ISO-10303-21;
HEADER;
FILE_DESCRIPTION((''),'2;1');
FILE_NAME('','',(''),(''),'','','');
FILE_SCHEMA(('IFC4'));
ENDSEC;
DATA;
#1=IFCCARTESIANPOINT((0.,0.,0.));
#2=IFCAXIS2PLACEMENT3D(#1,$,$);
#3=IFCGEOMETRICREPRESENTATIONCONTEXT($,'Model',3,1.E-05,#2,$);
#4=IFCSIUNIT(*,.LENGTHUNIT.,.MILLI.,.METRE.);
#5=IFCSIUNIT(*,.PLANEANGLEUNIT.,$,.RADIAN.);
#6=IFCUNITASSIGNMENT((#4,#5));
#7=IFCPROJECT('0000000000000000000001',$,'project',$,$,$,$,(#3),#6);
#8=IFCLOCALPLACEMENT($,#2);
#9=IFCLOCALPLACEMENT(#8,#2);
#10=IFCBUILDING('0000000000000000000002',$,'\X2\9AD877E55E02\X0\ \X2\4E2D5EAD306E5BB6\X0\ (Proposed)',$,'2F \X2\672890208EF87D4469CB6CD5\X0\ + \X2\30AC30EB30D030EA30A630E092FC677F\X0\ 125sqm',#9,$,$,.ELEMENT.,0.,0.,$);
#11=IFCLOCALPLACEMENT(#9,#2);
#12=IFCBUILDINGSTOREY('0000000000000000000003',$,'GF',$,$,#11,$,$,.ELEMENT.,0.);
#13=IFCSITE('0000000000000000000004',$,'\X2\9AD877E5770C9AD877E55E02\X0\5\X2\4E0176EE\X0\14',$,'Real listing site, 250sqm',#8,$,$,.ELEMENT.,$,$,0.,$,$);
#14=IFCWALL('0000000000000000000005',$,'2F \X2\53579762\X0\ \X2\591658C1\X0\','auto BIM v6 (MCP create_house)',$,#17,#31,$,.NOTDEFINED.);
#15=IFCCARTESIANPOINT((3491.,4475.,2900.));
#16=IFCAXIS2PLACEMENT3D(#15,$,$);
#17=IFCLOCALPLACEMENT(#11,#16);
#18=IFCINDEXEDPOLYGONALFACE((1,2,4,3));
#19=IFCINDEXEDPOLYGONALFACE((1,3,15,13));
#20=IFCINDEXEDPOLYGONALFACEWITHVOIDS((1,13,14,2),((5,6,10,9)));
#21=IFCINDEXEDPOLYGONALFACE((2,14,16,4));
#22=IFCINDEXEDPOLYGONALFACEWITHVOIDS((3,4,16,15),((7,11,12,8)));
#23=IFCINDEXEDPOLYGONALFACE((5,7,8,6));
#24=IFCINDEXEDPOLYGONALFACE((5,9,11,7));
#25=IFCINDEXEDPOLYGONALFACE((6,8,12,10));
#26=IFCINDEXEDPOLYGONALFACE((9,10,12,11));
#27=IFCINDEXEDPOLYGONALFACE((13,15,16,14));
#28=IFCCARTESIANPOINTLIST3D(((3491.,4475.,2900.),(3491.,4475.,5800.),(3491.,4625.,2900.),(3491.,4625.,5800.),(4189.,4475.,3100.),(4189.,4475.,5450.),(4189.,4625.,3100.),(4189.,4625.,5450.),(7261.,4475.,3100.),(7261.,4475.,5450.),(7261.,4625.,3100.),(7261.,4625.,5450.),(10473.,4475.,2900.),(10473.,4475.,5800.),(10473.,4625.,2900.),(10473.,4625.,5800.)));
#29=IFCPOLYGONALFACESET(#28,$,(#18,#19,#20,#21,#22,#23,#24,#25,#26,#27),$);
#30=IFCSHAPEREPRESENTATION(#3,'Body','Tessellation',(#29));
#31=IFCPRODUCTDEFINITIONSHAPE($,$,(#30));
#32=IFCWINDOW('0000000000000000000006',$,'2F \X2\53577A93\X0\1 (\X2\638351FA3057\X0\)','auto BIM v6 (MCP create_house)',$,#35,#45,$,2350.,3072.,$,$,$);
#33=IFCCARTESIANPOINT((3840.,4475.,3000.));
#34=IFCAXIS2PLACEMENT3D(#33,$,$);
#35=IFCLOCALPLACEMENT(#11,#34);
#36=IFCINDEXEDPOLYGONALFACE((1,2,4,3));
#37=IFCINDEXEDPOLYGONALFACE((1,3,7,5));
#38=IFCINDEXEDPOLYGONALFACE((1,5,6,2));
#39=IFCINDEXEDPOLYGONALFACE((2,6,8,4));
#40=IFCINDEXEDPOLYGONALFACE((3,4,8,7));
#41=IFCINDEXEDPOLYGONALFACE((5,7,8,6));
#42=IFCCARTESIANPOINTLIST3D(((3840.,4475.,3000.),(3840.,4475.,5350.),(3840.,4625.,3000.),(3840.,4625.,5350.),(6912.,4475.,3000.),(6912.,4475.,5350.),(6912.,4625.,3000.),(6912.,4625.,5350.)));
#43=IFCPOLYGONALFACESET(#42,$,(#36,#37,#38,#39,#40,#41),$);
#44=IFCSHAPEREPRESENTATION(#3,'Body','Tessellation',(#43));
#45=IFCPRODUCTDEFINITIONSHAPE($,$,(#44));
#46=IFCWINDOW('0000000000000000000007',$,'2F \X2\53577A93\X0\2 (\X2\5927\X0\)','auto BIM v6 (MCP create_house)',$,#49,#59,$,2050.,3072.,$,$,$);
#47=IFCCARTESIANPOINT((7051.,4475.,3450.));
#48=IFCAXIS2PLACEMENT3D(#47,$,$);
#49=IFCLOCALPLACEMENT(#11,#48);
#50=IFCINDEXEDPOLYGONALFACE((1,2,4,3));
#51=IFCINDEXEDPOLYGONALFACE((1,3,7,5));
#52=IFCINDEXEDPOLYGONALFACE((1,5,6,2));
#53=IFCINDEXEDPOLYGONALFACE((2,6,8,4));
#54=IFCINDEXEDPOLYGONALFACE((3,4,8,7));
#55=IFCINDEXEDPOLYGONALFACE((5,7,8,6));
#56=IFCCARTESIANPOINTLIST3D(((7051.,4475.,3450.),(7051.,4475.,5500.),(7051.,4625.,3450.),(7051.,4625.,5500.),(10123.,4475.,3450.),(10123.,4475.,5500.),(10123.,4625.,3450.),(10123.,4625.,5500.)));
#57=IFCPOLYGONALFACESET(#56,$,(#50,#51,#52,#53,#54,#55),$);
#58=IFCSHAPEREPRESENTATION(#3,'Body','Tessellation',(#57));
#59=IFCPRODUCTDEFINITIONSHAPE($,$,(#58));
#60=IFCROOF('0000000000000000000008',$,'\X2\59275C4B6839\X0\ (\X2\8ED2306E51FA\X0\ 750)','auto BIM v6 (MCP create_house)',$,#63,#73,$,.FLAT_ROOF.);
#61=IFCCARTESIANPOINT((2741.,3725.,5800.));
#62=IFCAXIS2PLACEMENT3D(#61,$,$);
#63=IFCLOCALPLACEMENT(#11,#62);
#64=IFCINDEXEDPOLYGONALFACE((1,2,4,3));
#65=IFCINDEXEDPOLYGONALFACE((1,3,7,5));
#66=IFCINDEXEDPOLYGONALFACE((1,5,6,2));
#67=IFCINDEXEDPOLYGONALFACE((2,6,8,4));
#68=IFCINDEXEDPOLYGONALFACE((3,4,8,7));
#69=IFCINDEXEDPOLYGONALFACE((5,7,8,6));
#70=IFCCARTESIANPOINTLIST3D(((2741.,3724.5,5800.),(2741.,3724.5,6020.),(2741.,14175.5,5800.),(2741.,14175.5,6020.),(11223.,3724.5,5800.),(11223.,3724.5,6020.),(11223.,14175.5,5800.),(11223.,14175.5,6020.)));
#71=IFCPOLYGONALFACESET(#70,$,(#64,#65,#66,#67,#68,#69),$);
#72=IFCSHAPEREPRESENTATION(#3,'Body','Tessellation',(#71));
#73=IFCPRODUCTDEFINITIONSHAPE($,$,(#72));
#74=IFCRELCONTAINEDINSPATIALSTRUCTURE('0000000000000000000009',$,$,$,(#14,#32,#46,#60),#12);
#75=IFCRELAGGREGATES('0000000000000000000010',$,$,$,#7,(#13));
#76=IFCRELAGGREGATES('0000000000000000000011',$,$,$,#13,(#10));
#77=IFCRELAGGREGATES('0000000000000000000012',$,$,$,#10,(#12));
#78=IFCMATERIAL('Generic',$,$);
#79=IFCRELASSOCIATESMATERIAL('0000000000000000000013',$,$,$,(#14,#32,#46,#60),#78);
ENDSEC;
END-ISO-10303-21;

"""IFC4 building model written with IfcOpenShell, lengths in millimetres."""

from ifc_helpers import new_model, si_unit, frame, frame_2d, origin, place, context, project, spatial, rectangle, extrude, material, element, fill, save


model = new_model("IFC4")

# Units and contexts
model_context = context("Model", 3, precision=1e-05, world=origin())
ifc_project = project(units=[si_unit("LENGTHUNIT", "METRE", prefix="MILLI"), si_unit("PLANEANGLEUNIT", "RADIAN")], contexts=[model_context])

# Site, building, storey
site_placement = place(None, origin())
site = spatial("IfcSite", under=ifc_project, at=site_placement, Name="高知県高知市5丁目14", ObjectType="Real listing site, 250sqm", CompositionType="ELEMENT", RefElevation=0.0)
building_placement = place(site_placement, origin())
building = spatial("IfcBuilding", under=site, at=building_placement, Name="高知市 中庭の家 (Proposed)", ObjectType="2F 木造軸組構法 + ガルバリウム鋼板 125sqm", CompositionType="ELEMENT", ElevationOfRefHeight=0.0, ElevationOfTerrain=0.0)
storey_placement = place(building_placement, origin())
storey = spatial("IfcBuildingStorey", under=building, at=storey_placement, Name="GF", CompositionType="ELEMENT", Elevation=0.0)

# Shared definitions
ifc_material = material(Name="Generic")

# Wall, openings, windows
wall_1_placement = place(storey_placement, frame((3491.0, 4475.0, 2900.0)))
wall_1 = element("IfcWall", 1, at=wall_1_placement, inside=storey, material=ifc_material, Name="2F 南面 外壁", Description="auto BIM v6 (MCP create_house)", PredefinedType="NOTDEFINED", context=model_context, shape_type="SweptSolid", body=[
    extrude(rectangle(XDim=6982.0, YDim=150.0, at=frame_2d((3491.0, 75.0))), frame((3491.0, 4475.0, 2900.0)), (0.0, 0.0, 1.0), 2900.0),
])
opening_1_placement = place(storey_placement, frame((3840.0, 4475.0, 3000.0)))
opening_1 = element("IfcOpeningElement", 2, at=opening_1_placement, cuts=wall_1, PredefinedType="NOTDEFINED", context=model_context, shape_type="SweptSolid", body=[
    extrude(rectangle(XDim=3072.0, YDim=150.0, at=frame_2d((1536.0, 75.0))), frame((3840.0, 4475.0, 3000.0)), (0.0, 0.0, 1.0), 2350.0),
])
opening_2_placement = place(storey_placement, frame((7051.0, 4475.0, 3450.0)))
opening_2 = element("IfcOpeningElement", 3, at=opening_2_placement, cuts=wall_1, PredefinedType="NOTDEFINED", context=model_context, shape_type="SweptSolid", body=[
    extrude(rectangle(XDim=3072.0, YDim=150.0, at=frame_2d((1536.0, 75.0))), frame((7051.0, 4475.0, 3450.0)), (0.0, 0.0, 1.0), 2050.0),
])
window_1_placement = place(storey_placement, frame((3840.0, 4475.0, 3000.0)))
window_1 = element("IfcWindow", 4, at=window_1_placement, inside=storey, material=ifc_material, Name="2F 南窓1 (掃出し)", Description="auto BIM v6 (MCP create_house)", OverallHeight=2350.0, OverallWidth=3072.0, context=model_context, shape_type="SweptSolid", body=[
    extrude(rectangle(XDim=3072.0, YDim=150.0, at=frame_2d((1536.0, 75.0))), frame((3840.0, 4475.0, 3000.0)), (0.0, 0.0, 1.0), 2350.0),
])
fill(opening_1, window_1)
window_2_placement = place(storey_placement, frame((7051.0, 4475.0, 3450.0)))
window_2 = element("IfcWindow", 5, at=window_2_placement, inside=storey, material=ifc_material, Name="2F 南窓2 (大)", Description="auto BIM v6 (MCP create_house)", OverallHeight=2050.0, OverallWidth=3072.0, context=model_context, shape_type="SweptSolid", body=[
    extrude(rectangle(XDim=3072.0, YDim=150.0, at=frame_2d((1536.0, 75.0))), frame((7051.0, 4475.0, 3450.0)), (0.0, 0.0, 1.0), 2050.0),
])
fill(opening_2, window_2)

# Roof
roof_placement = place(storey_placement, frame((2741.0, 3725.0, 5800.0)))
element("IfcRoof", 6, at=roof_placement, inside=storey, material=ifc_material, Name="大屋根 (軒の出 750)", Description="auto BIM v6 (MCP create_house)", PredefinedType="FLAT_ROOF", context=model_context, shape_type="SweptSolid", body=[
    extrude(rectangle(XDim=8482.0, YDim=10451.0, at=frame_2d((4241.0, 5225.0))), frame((2741.0, 3725.0, 5800.0)), (0.0, 0.0, 1.0), 220.0),
])

save(model, "model.ifc")
